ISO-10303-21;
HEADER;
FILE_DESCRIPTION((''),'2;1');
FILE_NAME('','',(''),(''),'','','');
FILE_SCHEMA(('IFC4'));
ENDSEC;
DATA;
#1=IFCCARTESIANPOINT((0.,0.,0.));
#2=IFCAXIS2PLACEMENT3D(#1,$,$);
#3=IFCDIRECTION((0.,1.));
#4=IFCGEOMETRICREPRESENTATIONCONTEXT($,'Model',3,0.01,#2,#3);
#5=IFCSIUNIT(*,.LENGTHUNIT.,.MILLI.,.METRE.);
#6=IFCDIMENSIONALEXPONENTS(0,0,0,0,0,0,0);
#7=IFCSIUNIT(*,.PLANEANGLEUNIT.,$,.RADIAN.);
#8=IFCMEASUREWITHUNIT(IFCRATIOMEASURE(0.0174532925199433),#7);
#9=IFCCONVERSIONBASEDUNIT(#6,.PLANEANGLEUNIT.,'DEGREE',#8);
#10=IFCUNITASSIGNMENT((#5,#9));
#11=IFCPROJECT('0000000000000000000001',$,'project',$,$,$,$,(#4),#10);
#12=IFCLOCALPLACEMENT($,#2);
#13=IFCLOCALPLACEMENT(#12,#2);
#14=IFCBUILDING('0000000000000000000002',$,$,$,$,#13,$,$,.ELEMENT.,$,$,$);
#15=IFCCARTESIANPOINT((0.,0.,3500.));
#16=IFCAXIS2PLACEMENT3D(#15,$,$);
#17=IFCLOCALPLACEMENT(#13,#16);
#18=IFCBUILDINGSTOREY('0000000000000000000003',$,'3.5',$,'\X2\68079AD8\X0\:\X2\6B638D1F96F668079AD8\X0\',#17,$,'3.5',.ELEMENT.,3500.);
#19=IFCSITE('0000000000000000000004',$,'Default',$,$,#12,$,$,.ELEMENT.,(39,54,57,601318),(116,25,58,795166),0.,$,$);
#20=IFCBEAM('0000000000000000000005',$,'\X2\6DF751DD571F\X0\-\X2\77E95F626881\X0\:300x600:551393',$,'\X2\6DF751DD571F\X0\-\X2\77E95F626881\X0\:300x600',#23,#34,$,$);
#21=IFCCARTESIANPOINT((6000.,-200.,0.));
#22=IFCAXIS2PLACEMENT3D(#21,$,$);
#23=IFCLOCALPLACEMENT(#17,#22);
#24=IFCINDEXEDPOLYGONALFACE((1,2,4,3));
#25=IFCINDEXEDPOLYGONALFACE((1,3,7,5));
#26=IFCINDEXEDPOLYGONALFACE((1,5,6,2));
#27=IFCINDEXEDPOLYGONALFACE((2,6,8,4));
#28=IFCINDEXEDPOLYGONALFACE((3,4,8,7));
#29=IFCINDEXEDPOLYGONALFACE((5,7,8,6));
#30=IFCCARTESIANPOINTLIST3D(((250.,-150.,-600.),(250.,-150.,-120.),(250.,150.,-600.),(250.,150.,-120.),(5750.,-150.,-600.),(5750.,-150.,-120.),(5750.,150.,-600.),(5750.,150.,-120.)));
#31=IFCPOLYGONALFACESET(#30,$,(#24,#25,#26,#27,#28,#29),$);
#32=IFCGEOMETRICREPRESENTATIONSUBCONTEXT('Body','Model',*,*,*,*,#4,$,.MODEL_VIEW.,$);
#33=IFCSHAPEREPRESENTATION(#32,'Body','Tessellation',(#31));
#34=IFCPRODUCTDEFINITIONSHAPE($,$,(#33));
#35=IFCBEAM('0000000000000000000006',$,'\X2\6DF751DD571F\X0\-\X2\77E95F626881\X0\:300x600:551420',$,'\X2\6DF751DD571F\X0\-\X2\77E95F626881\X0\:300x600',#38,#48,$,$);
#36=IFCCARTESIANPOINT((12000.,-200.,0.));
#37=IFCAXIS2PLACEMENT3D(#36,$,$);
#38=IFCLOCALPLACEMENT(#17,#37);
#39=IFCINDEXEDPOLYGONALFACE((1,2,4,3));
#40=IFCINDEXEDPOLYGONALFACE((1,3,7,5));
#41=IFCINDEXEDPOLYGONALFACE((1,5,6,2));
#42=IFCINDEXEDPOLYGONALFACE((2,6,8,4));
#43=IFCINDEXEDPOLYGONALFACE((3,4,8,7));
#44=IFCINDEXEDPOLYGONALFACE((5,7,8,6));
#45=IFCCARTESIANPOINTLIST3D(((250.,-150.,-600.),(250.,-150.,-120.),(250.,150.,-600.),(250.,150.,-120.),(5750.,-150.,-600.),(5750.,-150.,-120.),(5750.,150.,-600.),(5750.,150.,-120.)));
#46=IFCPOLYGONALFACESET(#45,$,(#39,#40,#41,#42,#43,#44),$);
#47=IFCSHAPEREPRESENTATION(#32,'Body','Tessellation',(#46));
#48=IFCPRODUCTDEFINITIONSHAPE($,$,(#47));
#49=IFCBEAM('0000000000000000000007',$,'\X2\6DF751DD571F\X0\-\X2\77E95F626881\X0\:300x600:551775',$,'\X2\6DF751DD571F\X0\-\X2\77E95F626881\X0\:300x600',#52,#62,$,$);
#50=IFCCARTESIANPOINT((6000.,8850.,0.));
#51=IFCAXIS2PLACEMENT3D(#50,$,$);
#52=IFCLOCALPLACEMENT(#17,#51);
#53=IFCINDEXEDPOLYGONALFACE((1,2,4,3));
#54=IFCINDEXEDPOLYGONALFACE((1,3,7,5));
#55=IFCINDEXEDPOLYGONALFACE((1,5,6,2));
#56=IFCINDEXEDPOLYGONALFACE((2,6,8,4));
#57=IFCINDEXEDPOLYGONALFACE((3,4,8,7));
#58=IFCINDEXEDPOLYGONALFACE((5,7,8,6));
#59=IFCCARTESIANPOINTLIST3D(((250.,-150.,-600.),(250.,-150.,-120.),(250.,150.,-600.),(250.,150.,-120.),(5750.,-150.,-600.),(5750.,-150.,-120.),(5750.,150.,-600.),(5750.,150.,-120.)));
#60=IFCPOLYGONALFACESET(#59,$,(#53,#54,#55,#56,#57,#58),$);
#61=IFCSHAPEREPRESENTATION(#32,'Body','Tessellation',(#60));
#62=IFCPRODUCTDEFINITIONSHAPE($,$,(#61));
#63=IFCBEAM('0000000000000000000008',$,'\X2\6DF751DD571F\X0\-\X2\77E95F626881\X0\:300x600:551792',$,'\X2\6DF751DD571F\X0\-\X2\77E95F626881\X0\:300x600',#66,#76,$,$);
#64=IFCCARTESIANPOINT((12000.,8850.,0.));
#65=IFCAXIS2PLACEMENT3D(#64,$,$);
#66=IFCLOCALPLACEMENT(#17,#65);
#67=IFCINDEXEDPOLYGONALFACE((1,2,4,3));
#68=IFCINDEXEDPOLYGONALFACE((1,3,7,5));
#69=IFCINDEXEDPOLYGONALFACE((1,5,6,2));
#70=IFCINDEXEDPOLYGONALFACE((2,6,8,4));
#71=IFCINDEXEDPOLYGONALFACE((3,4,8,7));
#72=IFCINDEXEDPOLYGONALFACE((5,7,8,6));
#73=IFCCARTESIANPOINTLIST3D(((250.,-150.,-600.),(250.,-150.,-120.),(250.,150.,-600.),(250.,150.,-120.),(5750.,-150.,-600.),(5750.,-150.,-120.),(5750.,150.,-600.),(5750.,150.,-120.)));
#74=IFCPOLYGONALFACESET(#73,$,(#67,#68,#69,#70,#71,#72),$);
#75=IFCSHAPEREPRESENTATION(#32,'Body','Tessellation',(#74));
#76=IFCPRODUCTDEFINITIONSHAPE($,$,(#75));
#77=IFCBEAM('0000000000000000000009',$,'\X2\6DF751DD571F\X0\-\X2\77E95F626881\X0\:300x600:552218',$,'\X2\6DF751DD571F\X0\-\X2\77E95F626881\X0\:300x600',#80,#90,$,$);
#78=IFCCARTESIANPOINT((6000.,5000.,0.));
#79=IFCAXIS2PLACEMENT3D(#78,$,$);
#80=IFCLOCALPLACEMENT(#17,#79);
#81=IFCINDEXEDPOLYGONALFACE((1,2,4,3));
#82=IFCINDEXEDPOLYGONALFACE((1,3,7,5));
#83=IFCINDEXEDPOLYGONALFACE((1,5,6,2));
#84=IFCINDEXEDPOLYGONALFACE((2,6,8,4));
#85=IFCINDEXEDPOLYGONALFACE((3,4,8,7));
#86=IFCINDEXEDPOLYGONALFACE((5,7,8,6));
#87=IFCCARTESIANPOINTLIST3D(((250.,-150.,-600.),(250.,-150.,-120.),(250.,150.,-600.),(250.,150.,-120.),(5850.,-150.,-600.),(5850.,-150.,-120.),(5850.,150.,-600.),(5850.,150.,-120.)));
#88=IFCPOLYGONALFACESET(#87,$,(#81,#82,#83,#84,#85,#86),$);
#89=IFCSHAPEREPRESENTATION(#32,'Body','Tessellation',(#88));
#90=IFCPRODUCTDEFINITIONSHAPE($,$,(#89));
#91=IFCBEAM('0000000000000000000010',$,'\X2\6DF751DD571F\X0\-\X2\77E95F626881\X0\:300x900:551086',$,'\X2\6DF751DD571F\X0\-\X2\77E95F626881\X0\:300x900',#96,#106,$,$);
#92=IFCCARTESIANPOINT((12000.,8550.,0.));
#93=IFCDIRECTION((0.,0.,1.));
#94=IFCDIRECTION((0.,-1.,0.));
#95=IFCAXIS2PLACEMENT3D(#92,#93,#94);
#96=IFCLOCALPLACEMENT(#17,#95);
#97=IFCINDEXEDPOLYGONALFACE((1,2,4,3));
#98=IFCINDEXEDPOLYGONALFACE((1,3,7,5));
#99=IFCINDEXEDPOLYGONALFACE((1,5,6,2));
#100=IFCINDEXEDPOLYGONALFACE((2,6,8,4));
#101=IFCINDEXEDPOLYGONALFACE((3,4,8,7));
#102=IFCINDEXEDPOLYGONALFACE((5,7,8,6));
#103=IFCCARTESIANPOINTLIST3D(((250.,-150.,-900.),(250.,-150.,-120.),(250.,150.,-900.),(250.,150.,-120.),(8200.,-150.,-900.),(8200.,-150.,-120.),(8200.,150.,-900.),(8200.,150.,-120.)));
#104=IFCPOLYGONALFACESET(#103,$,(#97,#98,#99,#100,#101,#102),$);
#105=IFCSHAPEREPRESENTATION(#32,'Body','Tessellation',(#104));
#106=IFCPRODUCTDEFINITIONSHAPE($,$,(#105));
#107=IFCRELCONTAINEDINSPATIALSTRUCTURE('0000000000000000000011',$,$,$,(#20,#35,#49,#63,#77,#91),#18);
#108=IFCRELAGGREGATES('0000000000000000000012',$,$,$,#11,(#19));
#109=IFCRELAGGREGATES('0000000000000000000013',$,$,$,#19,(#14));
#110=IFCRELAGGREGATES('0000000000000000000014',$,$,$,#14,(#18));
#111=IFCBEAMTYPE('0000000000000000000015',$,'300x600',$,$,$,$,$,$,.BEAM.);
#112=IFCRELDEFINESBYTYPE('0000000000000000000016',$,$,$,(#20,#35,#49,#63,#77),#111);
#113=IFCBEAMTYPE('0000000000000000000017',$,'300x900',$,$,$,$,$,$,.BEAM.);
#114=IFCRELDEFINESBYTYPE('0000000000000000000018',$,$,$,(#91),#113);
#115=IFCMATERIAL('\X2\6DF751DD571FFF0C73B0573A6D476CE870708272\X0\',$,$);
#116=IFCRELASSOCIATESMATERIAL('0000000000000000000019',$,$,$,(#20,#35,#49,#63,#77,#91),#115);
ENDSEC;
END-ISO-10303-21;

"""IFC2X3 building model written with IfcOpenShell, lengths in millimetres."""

from ifc_helpers import new_model, entity, si_unit, converted_unit, direction, frame, frame_2d, origin, place, context, subcontext, project, spatial, rectangle, extrude, material, type_object, element, save


model = new_model("IFC2X3")

# Units and contexts
model_context = context("Model", 3, precision=0.01, world=origin(), true_north=direction((0.0, 1.0)))
body_context = subcontext(model_context, "Body", "Model", "MODEL_VIEW")
ifc_project = project(units=[si_unit("LENGTHUNIT", "METRE", prefix="MILLI"), converted_unit("PLANEANGLEUNIT", "DEGREE", entity("IfcRatioMeasure", 0.0174532925199433), si_unit("PLANEANGLEUNIT", "RADIAN"), dimensions=[0, 0, 0, 0, 0, 0, 0])], contexts=[model_context])

# Site, building, storey
site_placement = place(None, origin())
site = spatial("IfcSite", under=ifc_project, at=site_placement, Name="Default", CompositionType="ELEMENT", RefLatitude=(39, 54, 57, 601318), RefLongitude=(116, 25, 58, 795166), RefElevation=0.0)
building_placement = place(site_placement, origin())
building = spatial("IfcBuilding", under=site, at=building_placement, CompositionType="ELEMENT")
storey_placement = place(building_placement, frame((0.0, 0.0, 3500.0)))
storey = spatial("IfcBuildingStorey", under=building, at=storey_placement, Name="3.5", ObjectType="标高:正负零标高", LongName="3.5", CompositionType="ELEMENT", Elevation=3500.0)

# Beams
ifc_material_1 = material(Name="混凝土，现场浇注灰色")
beam_type_1 = type_object("IfcBeamType", Name="300x600", PredefinedType="BEAM")
for number, where, name in (
    (1, (6000.0, -200.0, 0.0), "混凝土-矩形梁:300x600:551393"),
    (2, (12000.0, -200.0, 0.0), "混凝土-矩形梁:300x600:551420"),
):
    element("IfcBeam", number, at=place(storey_placement, frame(where)), inside=storey, type_object=beam_type_1, material=ifc_material_1, Name=name, ObjectType="混凝土-矩形梁:300x600", context=body_context, shape_type="SweptSolid", body=[
        extrude(rectangle(XDim=480.0, YDim=300.0, at=frame_2d((0.0, 0.0), x_axis=(1.0, 0.0))), frame((250.0, 0.0, -360.0), z_axis=(1.0, 0.0, 0.0), x_axis=(0.0, 0.0, -1.0)), (0.0, 0.0, 1.0), 5500.0),
    ])
beam_1_placement = place(storey_placement, frame((6000.0, 8850.0, 0.0)))
element("IfcBeam", 3, at=beam_1_placement, inside=storey, type_object=beam_type_1, material=ifc_material_1, Name="混凝土-矩形梁:300x600:551775", ObjectType="混凝土-矩形梁:300x600", context=body_context, shape_type="SweptSolid", body=[
    extrude(rectangle(XDim=480.0, YDim=300.0, at=frame_2d((0.0, 0.0), x_axis=(1.0, 0.0))), frame((250.0, 0.0, -360.0), z_axis=(1.0, 0.0, 0.0), x_axis=(0.0, 0.0, -1.0)), (0.0, 0.0, 1.0), 5500.0),
])
beam_2_placement = place(storey_placement, frame((12000.0, 8850.0, 0.0)))
element("IfcBeam", 4, at=beam_2_placement, inside=storey, type_object=beam_type_1, material=ifc_material_1, Name="混凝土-矩形梁:300x600:551792", ObjectType="混凝土-矩形梁:300x600", context=body_context, shape_type="SweptSolid", body=[
    extrude(rectangle(XDim=480.0, YDim=300.0, at=frame_2d((0.0, 0.0), x_axis=(1.0, 0.0))), frame((250.0, 0.0, -360.0), z_axis=(1.0, 0.0, 0.0), x_axis=(0.0, 0.0, -1.0)), (0.0, 0.0, 1.0), 5500.0),
])
beam_3_placement = place(storey_placement, frame((6000.0, 5000.0, 0.0)))
element("IfcBeam", 5, at=beam_3_placement, inside=storey, type_object=beam_type_1, material=ifc_material_1, Name="混凝土-矩形梁:300x600:552218", ObjectType="混凝土-矩形梁:300x600", context=body_context, shape_type="SweptSolid", body=[
    extrude(rectangle(XDim=480.0, YDim=300.0, at=frame_2d((0.0, 0.0), x_axis=(1.0, 0.0))), frame((250.0, 0.0, -360.0), z_axis=(1.0, 0.0, 0.0), x_axis=(0.0, 0.0, -1.0)), (0.0, 0.0, 1.0), 5600.0),
])
beam_type_2 = type_object("IfcBeamType", Name="300x900", PredefinedType="BEAM")
beam_4_placement = place(storey_placement, frame((12000.0, 8550.0, 0.0), z_axis=(0.0, 0.0, 1.0), x_axis=(0.0, -1.0, 0.0)))
element("IfcBeam", 6, at=beam_4_placement, inside=storey, type_object=beam_type_2, material=ifc_material_1, Name="混凝土-矩形梁:300x900:551086", ObjectType="混凝土-矩形梁:300x900", context=body_context, shape_type="SweptSolid", body=[
    extrude(rectangle(XDim=780.0, YDim=300.0, at=frame_2d((0.0, 0.0), x_axis=(1.0, 0.0))), frame((250.0, 0.0, -510.0), z_axis=(1.0, 0.0, 0.0), x_axis=(0.0, 0.0, -1.0)), (0.0, 0.0, 1.0), 7950.0),
])

save(model, "model.ifc")
